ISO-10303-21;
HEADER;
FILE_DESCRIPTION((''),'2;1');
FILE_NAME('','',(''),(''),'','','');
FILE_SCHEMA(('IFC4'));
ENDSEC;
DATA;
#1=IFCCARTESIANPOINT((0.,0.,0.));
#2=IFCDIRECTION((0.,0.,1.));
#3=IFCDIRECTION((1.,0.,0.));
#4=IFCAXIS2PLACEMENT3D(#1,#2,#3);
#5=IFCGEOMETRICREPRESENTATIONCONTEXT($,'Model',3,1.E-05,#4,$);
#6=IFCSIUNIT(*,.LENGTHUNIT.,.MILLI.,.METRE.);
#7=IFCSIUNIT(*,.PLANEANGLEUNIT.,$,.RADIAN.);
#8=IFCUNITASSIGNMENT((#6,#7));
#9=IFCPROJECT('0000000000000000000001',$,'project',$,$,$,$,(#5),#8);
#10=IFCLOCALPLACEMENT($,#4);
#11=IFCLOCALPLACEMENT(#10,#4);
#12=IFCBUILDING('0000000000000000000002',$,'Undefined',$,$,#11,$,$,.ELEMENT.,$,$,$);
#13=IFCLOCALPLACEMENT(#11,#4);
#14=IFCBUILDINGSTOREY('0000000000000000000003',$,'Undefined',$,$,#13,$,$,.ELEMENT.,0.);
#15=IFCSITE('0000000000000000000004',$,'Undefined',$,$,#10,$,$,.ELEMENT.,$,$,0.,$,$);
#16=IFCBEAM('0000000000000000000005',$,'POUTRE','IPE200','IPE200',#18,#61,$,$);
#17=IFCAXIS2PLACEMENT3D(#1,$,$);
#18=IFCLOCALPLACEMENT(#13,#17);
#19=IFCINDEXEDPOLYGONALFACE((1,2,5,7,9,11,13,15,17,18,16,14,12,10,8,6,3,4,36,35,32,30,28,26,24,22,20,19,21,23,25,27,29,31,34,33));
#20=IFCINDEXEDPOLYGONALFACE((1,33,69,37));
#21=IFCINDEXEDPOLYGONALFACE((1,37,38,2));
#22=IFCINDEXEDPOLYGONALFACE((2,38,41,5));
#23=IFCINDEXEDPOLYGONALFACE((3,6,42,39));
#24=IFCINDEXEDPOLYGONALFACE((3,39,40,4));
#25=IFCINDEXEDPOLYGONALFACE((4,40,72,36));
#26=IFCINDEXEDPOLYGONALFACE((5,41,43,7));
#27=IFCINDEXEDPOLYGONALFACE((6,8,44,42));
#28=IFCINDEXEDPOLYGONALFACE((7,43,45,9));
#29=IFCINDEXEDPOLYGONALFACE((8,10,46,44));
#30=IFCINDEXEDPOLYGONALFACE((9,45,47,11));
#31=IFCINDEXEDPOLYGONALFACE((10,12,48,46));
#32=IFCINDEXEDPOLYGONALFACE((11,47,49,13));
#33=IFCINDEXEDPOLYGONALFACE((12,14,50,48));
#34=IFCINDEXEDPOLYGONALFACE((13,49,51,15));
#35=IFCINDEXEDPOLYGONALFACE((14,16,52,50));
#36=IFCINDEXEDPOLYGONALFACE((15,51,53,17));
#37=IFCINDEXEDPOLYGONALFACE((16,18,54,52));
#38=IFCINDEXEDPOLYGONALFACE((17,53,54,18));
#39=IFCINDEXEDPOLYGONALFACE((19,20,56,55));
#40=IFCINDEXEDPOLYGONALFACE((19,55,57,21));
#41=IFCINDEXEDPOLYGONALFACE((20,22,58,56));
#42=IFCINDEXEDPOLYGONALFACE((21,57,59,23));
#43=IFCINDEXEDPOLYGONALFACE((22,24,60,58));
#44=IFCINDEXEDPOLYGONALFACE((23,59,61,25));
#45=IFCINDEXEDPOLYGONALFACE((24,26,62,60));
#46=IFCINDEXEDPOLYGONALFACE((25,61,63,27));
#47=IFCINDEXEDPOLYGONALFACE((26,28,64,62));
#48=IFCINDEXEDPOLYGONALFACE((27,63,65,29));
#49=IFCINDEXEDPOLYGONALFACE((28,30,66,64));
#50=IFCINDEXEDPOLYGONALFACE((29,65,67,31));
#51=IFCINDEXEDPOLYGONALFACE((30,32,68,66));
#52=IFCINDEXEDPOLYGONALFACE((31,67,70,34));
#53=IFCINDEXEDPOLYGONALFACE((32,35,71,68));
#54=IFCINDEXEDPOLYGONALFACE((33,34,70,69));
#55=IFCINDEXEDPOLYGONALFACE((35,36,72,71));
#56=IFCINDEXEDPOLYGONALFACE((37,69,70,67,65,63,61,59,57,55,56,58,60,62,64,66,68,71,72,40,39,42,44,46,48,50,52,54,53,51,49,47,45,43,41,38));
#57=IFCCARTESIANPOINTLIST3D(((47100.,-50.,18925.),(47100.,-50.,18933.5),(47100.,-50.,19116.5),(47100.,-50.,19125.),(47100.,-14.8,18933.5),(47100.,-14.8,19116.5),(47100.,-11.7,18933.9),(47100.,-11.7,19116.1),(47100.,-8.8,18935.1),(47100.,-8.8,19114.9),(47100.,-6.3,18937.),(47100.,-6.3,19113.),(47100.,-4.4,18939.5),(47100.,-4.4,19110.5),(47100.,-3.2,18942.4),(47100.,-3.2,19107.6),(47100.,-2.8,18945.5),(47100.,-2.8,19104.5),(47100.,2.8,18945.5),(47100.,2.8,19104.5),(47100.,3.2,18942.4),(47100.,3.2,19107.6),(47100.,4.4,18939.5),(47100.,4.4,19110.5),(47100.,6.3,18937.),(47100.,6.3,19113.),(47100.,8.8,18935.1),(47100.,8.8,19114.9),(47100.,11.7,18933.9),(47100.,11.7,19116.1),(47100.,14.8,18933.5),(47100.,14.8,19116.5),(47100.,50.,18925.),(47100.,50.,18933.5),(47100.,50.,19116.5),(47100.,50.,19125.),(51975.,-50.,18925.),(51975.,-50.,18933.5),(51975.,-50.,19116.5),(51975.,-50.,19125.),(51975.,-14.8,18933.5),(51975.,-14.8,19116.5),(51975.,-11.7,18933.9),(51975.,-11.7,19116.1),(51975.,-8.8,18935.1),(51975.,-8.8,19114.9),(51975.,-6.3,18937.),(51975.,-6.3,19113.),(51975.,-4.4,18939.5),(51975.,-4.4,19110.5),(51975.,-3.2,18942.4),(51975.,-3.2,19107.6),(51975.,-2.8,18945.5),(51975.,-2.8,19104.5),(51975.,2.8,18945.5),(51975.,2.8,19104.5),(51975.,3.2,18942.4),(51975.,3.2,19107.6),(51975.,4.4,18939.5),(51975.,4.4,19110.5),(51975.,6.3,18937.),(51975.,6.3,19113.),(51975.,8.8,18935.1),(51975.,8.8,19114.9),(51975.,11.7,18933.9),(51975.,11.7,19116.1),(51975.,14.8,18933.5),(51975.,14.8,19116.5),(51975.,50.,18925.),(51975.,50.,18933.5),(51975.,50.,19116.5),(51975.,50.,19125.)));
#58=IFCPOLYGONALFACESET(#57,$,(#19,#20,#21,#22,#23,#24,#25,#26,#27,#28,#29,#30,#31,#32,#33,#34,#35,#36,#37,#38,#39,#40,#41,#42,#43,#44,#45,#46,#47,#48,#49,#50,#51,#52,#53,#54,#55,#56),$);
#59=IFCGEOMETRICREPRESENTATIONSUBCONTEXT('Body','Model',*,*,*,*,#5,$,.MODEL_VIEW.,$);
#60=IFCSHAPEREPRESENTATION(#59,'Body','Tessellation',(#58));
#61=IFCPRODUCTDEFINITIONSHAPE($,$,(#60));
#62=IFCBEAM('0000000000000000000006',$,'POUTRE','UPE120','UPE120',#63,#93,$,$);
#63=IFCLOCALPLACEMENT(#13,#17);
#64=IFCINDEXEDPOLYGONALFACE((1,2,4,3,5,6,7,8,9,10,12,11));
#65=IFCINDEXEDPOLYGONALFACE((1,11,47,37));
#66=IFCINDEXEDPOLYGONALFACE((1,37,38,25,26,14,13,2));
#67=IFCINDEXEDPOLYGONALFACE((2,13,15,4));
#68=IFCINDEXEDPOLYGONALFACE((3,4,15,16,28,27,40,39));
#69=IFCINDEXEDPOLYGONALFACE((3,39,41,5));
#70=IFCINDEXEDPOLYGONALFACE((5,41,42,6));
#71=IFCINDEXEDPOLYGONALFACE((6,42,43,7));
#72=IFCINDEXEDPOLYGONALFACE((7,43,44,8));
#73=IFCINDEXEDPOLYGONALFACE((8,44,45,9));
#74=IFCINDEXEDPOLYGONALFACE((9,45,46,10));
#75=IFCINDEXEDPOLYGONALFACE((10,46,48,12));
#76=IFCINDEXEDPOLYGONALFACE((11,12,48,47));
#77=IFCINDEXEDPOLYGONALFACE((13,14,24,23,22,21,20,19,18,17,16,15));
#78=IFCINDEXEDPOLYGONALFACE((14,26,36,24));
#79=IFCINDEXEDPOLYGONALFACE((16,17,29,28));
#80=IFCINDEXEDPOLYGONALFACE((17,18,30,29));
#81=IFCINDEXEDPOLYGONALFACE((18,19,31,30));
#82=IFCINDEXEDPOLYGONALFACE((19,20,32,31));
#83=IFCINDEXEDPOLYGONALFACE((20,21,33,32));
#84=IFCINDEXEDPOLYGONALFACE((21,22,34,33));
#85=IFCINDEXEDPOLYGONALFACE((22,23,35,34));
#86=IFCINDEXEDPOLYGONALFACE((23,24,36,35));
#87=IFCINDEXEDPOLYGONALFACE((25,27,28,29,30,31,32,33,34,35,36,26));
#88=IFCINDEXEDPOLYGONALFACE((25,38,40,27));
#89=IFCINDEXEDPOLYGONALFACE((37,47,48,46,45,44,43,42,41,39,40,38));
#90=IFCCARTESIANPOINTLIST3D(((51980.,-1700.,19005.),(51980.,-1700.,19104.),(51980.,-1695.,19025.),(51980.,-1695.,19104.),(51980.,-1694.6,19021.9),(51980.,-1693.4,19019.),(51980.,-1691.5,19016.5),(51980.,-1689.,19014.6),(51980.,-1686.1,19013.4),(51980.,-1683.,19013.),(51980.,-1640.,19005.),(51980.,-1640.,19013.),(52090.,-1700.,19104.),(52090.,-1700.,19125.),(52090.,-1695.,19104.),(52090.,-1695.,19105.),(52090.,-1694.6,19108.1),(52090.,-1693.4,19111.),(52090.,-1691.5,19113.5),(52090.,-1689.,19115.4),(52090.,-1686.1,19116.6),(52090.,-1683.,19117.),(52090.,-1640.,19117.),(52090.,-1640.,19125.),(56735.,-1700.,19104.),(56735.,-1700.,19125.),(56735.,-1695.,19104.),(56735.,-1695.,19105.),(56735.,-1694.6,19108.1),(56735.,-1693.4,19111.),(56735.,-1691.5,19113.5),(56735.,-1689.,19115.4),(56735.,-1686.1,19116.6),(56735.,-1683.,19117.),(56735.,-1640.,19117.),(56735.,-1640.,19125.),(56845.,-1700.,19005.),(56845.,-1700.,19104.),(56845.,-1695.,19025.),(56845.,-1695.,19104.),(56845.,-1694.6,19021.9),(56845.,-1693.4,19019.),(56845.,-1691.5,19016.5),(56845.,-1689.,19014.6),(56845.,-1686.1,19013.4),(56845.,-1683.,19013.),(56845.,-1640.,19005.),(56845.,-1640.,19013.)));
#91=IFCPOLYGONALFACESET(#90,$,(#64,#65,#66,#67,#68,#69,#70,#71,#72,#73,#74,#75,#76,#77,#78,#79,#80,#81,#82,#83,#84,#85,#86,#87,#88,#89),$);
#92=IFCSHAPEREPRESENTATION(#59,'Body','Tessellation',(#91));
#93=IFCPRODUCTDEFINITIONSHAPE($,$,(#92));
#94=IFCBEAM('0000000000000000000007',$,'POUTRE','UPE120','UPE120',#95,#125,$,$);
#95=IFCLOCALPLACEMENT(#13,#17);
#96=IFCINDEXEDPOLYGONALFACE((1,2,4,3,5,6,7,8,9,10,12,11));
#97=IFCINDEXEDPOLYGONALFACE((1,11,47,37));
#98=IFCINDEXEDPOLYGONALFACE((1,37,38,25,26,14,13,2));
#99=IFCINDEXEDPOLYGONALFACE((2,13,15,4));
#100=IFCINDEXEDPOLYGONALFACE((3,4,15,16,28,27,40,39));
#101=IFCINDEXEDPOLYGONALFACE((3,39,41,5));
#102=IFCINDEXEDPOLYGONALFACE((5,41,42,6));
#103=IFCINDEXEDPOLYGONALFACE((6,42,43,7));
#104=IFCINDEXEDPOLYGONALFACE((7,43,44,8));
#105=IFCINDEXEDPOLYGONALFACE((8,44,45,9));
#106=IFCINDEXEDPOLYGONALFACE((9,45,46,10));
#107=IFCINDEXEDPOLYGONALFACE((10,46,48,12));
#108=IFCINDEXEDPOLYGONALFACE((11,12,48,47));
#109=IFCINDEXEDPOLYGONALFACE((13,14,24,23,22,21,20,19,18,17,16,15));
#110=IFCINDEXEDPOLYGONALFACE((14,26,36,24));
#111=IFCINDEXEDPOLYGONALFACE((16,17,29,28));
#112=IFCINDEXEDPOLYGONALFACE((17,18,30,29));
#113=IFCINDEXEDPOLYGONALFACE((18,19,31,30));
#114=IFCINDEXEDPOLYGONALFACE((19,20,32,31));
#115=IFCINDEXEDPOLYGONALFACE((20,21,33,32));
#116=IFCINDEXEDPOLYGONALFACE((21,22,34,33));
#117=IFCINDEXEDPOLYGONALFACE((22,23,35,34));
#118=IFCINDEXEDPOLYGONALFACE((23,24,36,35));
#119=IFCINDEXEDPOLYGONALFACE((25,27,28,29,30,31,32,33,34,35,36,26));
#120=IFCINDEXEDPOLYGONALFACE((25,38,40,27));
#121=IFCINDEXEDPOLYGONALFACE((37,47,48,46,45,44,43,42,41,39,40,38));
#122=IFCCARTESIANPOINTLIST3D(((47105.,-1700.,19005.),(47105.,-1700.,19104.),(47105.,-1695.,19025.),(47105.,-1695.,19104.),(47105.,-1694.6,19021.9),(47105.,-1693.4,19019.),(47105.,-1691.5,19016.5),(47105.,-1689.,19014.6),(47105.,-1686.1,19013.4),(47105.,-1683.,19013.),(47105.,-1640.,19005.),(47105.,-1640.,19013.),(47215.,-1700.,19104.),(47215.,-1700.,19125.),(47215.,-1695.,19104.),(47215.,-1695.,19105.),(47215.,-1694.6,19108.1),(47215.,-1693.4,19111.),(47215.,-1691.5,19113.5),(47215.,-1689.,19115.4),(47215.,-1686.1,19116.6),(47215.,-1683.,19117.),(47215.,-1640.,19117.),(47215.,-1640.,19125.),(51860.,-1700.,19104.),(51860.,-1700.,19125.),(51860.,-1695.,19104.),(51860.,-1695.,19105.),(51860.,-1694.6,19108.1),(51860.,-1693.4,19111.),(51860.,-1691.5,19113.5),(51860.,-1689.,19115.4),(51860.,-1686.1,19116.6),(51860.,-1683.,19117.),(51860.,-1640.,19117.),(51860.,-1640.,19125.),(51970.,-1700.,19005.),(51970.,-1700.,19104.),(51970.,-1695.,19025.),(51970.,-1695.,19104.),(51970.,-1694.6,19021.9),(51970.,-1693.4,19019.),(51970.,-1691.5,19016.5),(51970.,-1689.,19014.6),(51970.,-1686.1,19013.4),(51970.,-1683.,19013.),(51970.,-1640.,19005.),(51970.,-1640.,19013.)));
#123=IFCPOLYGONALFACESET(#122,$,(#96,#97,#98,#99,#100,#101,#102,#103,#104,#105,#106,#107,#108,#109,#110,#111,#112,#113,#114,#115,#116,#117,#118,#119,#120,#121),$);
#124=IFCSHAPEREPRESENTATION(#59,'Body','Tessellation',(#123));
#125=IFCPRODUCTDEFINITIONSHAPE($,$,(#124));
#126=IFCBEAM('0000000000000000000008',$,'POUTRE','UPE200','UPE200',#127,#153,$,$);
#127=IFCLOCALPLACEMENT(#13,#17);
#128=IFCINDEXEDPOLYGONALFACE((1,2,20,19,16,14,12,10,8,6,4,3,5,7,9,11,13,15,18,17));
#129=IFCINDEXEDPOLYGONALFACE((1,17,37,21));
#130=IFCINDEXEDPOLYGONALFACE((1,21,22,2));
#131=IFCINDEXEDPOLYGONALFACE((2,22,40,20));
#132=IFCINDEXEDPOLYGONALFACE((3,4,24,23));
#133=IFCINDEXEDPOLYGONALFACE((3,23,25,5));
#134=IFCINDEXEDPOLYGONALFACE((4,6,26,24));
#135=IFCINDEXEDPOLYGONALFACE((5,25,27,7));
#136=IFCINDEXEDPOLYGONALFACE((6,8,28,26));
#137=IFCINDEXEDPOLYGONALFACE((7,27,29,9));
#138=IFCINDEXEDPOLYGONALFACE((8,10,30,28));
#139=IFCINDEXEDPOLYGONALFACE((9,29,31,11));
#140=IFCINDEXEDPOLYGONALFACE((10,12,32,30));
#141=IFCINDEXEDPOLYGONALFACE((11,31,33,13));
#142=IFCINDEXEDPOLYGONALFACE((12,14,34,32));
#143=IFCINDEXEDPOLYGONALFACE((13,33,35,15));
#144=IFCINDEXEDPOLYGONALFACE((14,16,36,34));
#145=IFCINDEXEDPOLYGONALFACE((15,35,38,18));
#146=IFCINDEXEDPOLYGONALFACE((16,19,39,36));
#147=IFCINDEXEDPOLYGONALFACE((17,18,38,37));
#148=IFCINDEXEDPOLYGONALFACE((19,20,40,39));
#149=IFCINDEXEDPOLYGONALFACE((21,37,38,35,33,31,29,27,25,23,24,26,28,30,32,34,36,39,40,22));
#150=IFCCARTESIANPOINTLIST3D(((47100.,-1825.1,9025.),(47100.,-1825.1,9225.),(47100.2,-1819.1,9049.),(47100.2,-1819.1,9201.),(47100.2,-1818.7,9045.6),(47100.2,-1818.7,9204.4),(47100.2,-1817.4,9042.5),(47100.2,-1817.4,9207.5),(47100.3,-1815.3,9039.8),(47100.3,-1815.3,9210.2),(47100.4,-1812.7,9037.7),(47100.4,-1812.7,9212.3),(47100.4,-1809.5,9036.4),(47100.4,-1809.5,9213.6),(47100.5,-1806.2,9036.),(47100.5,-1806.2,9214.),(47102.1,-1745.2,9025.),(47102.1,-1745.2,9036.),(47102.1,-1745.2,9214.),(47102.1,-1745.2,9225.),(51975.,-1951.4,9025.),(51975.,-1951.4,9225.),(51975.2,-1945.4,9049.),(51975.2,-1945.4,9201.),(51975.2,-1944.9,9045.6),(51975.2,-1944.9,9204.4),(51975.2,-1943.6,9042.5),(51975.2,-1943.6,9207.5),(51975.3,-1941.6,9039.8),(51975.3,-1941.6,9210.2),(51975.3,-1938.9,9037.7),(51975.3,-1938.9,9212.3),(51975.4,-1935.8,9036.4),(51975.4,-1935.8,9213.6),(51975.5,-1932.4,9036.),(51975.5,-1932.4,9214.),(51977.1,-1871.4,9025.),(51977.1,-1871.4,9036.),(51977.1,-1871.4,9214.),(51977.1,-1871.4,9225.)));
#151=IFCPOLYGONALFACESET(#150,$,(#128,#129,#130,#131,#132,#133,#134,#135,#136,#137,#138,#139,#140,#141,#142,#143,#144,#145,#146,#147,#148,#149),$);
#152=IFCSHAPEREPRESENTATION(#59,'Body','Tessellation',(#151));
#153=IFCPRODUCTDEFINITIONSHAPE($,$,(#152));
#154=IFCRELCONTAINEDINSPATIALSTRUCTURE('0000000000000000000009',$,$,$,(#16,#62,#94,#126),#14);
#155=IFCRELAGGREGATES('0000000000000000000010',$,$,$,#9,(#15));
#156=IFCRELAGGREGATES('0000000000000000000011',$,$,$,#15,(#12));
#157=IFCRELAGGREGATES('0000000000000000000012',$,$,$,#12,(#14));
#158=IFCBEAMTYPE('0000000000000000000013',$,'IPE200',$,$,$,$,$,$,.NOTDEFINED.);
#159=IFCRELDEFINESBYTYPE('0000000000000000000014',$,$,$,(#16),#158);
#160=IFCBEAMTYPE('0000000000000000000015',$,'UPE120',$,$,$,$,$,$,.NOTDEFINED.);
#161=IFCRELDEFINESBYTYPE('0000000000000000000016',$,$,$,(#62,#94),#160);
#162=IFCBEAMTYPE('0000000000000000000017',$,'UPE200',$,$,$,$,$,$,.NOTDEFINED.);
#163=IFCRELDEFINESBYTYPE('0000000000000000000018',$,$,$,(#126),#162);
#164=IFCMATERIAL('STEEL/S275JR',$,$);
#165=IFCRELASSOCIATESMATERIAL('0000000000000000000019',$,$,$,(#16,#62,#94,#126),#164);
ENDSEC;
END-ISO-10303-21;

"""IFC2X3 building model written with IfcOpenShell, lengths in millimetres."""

from ifc_helpers import new_model, si_unit, frame, origin_with_axes, origin_2d_with_axis, place, context, subcontext, project, spatial, rectangle, i_section, u_section, extrude, boolean, material, type_object, element, save


model = new_model("IFC2X3")

# Units and contexts
model_context = context("Model", 3, precision=1e-05, world=origin_with_axes())
body_context = subcontext(model_context, "Body", "Model", "MODEL_VIEW")
ifc_project = project(units=[si_unit("LENGTHUNIT", "METRE", prefix="MILLI"), si_unit("PLANEANGLEUNIT", "RADIAN")], contexts=[model_context])

# Site, building, storey
site_placement = place(None, origin_with_axes())
site = spatial("IfcSite", under=ifc_project, at=site_placement, Name="Undefined", CompositionType="ELEMENT", RefElevation=0.0)
building_placement = place(site_placement, origin_with_axes())
building = spatial("IfcBuilding", under=site, at=building_placement, Name="Undefined", CompositionType="ELEMENT")
storey_placement = place(building_placement, origin_with_axes())
storey = spatial("IfcBuildingStorey", under=building, at=storey_placement, Name="Undefined", CompositionType="ELEMENT", Elevation=0.0)

# Shared definitions
ifc_material_1 = material(Name="STEEL/S275JR")

# Beams
beam_type_1 = type_object("IfcBeamType", Name="IPE200", PredefinedType="NOTDEFINED")
beam_1_placement = place(storey_placement, frame((47100.0, 0.0, 19025.0), z_axis=(-0.000006, 0.0, 1.0), x_axis=(1.0, 0.0, 0.000006)))
element("IfcBeam", 1, at=beam_1_placement, inside=storey, type_object=beam_type_1, material=ifc_material_1, Name="POUTRE", Description="IPE200", ObjectType="IPE200", context=body_context, shape_type="SweptSolid", body=[
    extrude(i_section(OverallWidth=100.0, OverallDepth=200.0, WebThickness=5.6, FlangeThickness=8.5, FilletRadius=12.0, at=origin_2d_with_axis()), frame((4875.0, 0.0, 0.0), z_axis=(-1.0, 0.0, 0.0), x_axis=(0.0, -1.0, 0.0)), (0.0, 0.0, 1.0), 4875.0),
])
beam_type_2 = type_object("IfcBeamType", Name="UPE120", PredefinedType="NOTDEFINED")
beam_2_placement = place(storey_placement, frame((51984.7, -1670.0, 19065.0), z_axis=(0.0, 0.0, -1.0), x_axis=(1.0, 0.0, 0.0)))
element("IfcBeam", 2, at=beam_2_placement, inside=storey, type_object=beam_type_2, material=ifc_material_1, Name="POUTRE", Description="UPE120", ObjectType="UPE120", context=body_context, shape_type="CSG", body=[
    boolean("DIFFERENCE", boolean("DIFFERENCE", extrude(u_section(Depth=120.0, FlangeWidth=60.0, WebThickness=5.0, FlangeThickness=8.0, FilletRadius=12.0, at=origin_2d_with_axis()), frame((4860.3, 0.0, 0.0), z_axis=(-1.0, 0.0, 0.0), x_axis=(0.0, -1.0, 0.0)), (0.0, 0.0, 1.0), 4865.0), extrude(rectangle(XDim=22.0, YDim=112.0, at=origin_2d_with_axis()), frame((49.3, 31.0, -50.0), z_axis=(0.0, -1.0, 0.0), x_axis=(0.0, 0.0, 1.0)), (0.0, 0.0, 1.0), 62.0)), extrude(rectangle(XDim=22.0, YDim=112.0, at=origin_2d_with_axis()), frame((4806.3, -31.0, -50.0), z_axis=(0.0, 1.0, 0.0), x_axis=(0.0, 0.0, 1.0)), (0.0, 0.0, 1.0), 62.0)),
])
beam_3_placement = place(storey_placement, frame((47109.7, -1670.0, 19065.0), z_axis=(0.0, 0.0, -1.0), x_axis=(1.0, 0.0, 0.0)))
element("IfcBeam", 3, at=beam_3_placement, inside=storey, type_object=beam_type_2, material=ifc_material_1, Name="POUTRE", Description="UPE120", ObjectType="UPE120", context=body_context, shape_type="CSG", body=[
    boolean("DIFFERENCE", boolean("DIFFERENCE", extrude(u_section(Depth=120.0, FlangeWidth=60.0, WebThickness=5.0, FlangeThickness=8.0, FilletRadius=12.0, at=origin_2d_with_axis()), frame((4860.3, 0.0, 0.0), z_axis=(-1.0, 0.0, 0.0), x_axis=(0.0, -1.0, 0.0)), (0.0, 0.0, 1.0), 4865.0), extrude(rectangle(XDim=22.0, YDim=112.0, at=origin_2d_with_axis()), frame((49.3, 31.0, -50.0), z_axis=(0.0, -1.0, 0.0), x_axis=(0.0, 0.0, 1.0)), (0.0, 0.0, 1.0), 62.0)), extrude(rectangle(XDim=22.0, YDim=112.0, at=origin_2d_with_axis()), frame((4806.3, -31.0, -50.0), z_axis=(0.0, 1.0, 0.0), x_axis=(0.0, 0.0, 1.0)), (0.0, 0.0, 1.0), 62.0)),
])
beam_type_3 = type_object("IfcBeamType", Name="UPE200", PredefinedType="NOTDEFINED")
beam_4_placement = place(storey_placement, frame((47101.0, -1785.2, 9125.0), z_axis=(0.0, 0.0, -1.0), x_axis=(0.999665, -0.025886, 0.0)))
element("IfcBeam", 4, at=beam_4_placement, inside=storey, type_object=beam_type_3, material=ifc_material_1, Name="POUTRE", Description="UPE200", ObjectType="UPE200", context=body_context, shape_type="SweptSolid", body=[
    extrude(u_section(Depth=200.0, FlangeWidth=80.0, WebThickness=6.0, FlangeThickness=11.0, FilletRadius=13.0, at=origin_2d_with_axis()), frame((4876.6, 0.0, 0.0), z_axis=(-1.0, 0.0, 0.0), x_axis=(0.0, -1.0, 0.0)), (0.0, 0.0, 1.0), 4876.6),
])

save(model, "model.ifc")
